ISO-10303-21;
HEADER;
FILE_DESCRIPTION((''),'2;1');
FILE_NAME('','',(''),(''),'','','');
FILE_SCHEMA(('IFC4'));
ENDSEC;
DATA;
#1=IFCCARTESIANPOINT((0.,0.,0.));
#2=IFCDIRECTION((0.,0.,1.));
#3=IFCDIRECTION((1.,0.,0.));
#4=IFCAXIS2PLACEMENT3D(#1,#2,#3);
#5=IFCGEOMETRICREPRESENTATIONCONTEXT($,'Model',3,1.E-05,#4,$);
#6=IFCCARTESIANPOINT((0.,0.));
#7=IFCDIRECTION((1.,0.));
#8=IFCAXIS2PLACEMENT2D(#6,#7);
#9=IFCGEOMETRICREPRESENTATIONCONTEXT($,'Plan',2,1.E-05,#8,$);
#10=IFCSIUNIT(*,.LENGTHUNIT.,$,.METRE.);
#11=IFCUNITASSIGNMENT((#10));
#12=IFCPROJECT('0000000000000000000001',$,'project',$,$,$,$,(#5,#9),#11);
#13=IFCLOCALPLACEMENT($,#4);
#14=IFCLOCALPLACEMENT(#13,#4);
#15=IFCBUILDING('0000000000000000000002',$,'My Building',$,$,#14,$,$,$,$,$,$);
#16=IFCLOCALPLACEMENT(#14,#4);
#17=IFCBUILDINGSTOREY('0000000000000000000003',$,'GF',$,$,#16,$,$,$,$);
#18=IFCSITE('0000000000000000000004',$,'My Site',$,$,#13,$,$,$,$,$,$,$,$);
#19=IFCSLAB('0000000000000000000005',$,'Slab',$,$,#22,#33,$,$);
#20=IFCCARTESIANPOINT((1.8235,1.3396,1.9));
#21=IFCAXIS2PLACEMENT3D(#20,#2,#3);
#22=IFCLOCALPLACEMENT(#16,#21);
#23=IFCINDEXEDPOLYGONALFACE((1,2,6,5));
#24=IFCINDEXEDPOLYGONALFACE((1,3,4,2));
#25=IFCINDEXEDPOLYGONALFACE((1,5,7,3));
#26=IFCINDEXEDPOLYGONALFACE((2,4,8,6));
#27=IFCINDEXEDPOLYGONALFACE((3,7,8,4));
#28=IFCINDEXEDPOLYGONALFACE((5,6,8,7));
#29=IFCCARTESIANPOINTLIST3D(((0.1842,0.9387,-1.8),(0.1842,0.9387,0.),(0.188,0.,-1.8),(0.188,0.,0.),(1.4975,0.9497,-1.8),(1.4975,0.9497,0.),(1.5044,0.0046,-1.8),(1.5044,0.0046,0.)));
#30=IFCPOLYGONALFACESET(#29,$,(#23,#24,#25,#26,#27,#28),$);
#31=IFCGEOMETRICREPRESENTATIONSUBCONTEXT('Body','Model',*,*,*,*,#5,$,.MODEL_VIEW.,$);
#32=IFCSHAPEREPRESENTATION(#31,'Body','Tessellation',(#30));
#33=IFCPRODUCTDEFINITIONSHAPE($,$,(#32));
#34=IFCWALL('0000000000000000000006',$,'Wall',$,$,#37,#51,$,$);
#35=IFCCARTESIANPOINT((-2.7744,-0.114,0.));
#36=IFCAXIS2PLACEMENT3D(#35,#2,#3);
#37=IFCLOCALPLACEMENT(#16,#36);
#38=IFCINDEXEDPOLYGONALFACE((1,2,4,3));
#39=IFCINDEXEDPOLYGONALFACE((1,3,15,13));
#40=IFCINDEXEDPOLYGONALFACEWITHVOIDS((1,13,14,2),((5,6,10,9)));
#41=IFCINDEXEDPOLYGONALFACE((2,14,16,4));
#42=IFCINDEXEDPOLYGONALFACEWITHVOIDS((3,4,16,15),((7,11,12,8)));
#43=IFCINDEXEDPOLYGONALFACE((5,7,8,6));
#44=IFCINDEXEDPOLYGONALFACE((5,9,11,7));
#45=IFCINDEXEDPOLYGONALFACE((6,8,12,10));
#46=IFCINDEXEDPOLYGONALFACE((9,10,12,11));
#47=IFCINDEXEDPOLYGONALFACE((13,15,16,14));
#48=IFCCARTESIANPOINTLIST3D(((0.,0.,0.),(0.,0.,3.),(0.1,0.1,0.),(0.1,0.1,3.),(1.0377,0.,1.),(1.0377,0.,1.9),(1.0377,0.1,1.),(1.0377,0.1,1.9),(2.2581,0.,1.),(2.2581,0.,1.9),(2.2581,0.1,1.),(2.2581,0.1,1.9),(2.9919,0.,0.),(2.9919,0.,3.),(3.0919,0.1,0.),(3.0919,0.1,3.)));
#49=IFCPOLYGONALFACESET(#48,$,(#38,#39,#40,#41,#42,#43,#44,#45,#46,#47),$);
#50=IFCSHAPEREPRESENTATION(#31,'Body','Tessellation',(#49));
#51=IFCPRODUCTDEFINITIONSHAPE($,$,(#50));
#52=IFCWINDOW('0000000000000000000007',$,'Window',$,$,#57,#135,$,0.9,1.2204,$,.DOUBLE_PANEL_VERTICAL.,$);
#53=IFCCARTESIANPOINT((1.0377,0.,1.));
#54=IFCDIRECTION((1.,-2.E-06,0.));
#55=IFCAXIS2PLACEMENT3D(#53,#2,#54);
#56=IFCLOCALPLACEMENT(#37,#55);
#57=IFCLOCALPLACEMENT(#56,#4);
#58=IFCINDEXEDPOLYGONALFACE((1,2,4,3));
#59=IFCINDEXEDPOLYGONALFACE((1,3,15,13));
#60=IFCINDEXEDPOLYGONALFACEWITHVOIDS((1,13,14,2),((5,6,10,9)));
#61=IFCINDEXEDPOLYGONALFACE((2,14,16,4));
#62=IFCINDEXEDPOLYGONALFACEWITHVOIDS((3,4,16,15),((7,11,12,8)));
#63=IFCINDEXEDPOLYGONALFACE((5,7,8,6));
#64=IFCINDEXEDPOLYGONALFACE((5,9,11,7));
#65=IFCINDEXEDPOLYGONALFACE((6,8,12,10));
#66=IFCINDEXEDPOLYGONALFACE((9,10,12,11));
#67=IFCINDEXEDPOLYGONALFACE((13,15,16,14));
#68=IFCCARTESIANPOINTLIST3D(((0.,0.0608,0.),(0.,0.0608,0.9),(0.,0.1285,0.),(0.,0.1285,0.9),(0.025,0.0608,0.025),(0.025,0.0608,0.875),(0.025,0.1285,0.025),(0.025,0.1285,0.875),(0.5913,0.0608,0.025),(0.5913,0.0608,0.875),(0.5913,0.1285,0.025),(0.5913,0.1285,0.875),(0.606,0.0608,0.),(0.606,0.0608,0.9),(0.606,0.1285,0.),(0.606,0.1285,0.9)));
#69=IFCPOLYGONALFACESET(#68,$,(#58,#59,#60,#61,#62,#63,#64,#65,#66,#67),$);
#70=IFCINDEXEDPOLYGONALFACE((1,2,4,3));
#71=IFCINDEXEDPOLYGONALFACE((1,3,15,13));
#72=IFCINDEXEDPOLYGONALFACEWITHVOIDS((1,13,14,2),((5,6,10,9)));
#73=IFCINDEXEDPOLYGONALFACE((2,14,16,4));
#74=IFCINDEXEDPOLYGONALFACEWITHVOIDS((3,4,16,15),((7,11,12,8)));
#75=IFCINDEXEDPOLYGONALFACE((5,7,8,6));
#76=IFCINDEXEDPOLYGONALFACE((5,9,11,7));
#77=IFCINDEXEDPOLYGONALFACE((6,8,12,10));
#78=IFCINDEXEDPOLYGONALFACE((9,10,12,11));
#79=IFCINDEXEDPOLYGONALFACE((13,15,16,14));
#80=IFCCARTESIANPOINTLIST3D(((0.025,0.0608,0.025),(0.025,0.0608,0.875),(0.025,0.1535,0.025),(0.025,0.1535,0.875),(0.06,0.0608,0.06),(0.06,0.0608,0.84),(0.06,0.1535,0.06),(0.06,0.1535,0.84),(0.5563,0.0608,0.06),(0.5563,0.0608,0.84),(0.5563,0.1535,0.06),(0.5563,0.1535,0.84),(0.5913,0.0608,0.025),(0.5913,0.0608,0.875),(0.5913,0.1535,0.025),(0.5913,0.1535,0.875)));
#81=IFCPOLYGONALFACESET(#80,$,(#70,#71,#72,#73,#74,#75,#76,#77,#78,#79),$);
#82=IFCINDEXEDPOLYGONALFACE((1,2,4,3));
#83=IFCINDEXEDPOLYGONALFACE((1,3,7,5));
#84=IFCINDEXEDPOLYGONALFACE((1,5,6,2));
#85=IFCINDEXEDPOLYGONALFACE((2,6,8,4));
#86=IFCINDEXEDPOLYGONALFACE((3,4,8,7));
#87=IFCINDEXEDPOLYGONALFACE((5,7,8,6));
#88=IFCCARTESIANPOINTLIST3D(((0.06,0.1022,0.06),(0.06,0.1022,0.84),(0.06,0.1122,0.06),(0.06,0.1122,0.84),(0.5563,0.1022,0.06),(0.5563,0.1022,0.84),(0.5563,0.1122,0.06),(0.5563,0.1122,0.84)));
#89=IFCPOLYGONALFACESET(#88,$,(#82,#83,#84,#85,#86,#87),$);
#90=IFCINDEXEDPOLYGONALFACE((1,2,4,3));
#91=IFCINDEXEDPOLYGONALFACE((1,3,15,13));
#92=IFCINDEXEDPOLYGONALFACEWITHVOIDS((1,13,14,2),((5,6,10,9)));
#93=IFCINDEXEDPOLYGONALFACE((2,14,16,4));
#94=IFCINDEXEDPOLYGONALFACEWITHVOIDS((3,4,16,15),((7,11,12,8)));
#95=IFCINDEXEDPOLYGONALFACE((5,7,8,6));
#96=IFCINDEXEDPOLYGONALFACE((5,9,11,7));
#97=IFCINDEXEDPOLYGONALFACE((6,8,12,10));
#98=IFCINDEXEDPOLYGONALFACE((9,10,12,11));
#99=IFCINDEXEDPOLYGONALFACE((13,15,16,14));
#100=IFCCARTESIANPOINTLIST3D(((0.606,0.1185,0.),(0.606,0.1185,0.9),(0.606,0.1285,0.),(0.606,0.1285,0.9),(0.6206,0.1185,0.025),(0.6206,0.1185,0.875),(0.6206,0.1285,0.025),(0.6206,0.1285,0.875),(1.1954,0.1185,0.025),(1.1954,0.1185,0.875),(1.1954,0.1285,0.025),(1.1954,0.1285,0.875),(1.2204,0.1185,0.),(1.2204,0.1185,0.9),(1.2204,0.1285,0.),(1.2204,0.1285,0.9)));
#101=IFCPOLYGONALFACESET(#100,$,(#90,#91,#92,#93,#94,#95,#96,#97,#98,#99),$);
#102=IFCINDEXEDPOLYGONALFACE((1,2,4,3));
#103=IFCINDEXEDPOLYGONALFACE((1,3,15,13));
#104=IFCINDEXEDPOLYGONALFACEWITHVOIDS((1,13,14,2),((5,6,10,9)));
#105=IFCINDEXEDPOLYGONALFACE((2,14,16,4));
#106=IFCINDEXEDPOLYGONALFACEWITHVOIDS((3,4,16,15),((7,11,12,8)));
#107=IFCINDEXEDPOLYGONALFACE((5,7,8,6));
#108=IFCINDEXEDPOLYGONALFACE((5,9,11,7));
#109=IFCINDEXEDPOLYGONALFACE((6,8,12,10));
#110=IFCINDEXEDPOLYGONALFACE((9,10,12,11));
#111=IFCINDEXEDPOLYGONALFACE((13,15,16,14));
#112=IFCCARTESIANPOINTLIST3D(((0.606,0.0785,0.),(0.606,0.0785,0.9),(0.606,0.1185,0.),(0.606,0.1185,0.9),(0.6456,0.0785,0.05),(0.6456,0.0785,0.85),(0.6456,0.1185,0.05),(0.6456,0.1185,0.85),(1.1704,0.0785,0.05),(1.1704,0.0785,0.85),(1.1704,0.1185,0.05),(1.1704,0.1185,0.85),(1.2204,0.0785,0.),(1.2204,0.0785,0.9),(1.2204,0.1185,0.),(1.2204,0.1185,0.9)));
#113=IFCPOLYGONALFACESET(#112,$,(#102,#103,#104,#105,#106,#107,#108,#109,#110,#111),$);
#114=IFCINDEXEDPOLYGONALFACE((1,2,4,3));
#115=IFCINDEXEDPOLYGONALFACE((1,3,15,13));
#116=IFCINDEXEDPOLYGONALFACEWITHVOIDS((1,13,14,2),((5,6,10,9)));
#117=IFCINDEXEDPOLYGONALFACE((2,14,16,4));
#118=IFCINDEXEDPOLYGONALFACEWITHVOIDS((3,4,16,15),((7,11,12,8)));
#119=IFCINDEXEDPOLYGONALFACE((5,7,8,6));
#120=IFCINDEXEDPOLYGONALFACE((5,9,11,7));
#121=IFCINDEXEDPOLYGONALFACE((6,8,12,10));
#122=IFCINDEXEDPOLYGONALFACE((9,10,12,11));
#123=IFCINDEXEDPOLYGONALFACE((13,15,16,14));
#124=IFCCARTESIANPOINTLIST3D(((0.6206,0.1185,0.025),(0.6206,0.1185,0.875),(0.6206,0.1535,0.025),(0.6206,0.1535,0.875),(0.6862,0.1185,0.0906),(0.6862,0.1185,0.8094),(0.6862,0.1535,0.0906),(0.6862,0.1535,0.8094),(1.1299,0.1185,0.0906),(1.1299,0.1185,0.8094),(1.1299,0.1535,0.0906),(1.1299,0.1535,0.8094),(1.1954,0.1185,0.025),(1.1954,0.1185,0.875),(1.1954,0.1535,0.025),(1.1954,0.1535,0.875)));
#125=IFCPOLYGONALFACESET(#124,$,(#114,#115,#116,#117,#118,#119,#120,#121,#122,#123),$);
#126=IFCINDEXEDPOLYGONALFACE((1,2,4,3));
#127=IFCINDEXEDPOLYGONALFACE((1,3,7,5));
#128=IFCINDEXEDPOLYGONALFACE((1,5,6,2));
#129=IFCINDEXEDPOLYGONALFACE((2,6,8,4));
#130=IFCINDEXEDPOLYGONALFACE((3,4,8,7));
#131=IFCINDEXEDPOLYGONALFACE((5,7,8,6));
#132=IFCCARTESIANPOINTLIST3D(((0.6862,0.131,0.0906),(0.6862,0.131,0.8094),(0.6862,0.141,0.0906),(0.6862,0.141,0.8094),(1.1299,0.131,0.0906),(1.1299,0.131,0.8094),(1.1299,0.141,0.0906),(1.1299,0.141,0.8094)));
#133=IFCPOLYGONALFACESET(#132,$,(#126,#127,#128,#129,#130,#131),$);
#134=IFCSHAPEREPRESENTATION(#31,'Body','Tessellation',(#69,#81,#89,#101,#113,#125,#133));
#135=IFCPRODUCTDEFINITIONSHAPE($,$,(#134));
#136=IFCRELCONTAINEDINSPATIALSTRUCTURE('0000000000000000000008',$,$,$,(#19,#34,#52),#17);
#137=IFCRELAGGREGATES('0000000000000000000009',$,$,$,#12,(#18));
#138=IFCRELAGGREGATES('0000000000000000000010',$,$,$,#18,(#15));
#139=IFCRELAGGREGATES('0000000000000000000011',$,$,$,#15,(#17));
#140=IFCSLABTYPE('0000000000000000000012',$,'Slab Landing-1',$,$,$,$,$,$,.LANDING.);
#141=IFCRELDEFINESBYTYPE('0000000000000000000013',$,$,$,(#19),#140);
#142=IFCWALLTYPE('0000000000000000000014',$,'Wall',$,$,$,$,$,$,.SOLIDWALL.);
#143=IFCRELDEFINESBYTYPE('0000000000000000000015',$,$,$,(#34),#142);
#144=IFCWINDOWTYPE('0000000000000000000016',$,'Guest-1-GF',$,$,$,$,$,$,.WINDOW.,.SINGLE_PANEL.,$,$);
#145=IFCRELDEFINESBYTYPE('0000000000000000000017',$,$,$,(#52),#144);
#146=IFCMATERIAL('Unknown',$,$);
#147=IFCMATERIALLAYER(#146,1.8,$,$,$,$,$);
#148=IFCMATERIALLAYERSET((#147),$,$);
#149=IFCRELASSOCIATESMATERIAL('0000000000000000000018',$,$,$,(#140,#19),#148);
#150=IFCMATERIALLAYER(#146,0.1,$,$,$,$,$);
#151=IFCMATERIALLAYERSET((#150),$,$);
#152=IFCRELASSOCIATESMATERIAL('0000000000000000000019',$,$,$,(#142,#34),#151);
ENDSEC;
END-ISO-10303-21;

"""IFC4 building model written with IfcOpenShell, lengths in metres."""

from ifc_helpers import new_model, entity, si_unit, frame, origin_with_axes, origin_2d_with_axis, place, context, subcontext, project, spatial, line, indexed_curve, outline, extrude, shape, source, transform, mapped, material, layer, layer_set, layer_usage, type_object, type_shapes, element, fill, save


model = new_model("IFC4")

# Units and contexts
model_context = context("Model", 3, precision=1e-05, world=origin_with_axes())
plan_context = context("Plan", 2, precision=1e-05, world=origin_2d_with_axis())
body_context_1 = subcontext(model_context, "Body", "Model", "MODEL_VIEW")
body_context_2 = subcontext(plan_context, "Body", "Plan", "PLAN_VIEW")
ifc_project = project(units=[si_unit("LENGTHUNIT", "METRE")], contexts=[model_context, plan_context])

# Site, building, storey
site_placement = place(None, origin_with_axes())
site = spatial("IfcSite", under=ifc_project, at=site_placement, Name="My Site")
building_placement = place(site_placement, origin_with_axes())
building = spatial("IfcBuilding", under=site, at=building_placement, Name="My Building")
storey_placement = place(building_placement, origin_with_axes())
storey = spatial("IfcBuildingStorey", under=building, at=storey_placement, Name="GF")

# Slab
ifc_material_1 = material(Name="Unknown")
ifc_layer_1 = layer(ifc_material_1, 1.8)
ifc_layer_set_1 = layer_set([ifc_layer_1])
ifc_layer_usage_1 = layer_usage(ifc_layer_set_1, "AXIS3", "POSITIVE", -1.8)
slab_type_1 = type_object("IfcSlabType", Name="Slab Landing-1", PredefinedType="LANDING", material=ifc_layer_set_1)
slab_1_placement = place(storey_placement, frame((1.8235, 1.3396, 1.9), z_axis=(0.0, 0.0, 1.0), x_axis=(1.0, 0.0, 0.0)))
element("IfcSlab", 1, at=slab_1_placement, inside=storey, type_object=slab_type_1, material=ifc_layer_usage_1, Name="Slab", context=body_context_1, shape_type="SweptSolid", body=[
    extrude(outline(indexed_curve([(0.1842, 0.9387), (1.4975, 0.9497), (1.5044, 0.0046), (0.188, 0.0), (0.1842, 0.9387)])), frame((0.0, 0.0, -1.8), z_axis=(0.0, 0.0, 1.0), x_axis=(1.0, 0.0, 0.0)), (0.0, 0.0, 1.0), 1.8),
])

# Shared definitions
ifc_layer_2 = layer(ifc_material_1, 0.1)
ifc_layer_set_2 = layer_set([ifc_layer_2])
wall_type = type_object("IfcWallType", Name="Wall", PredefinedType="SOLIDWALL", material=ifc_layer_set_2)

# Wall, opening, window
ifc_layer_usage_2 = layer_usage(ifc_layer_set_2, "AXIS2", "POSITIVE", 0.0)
wall_1_placement = place(storey_placement, frame((-2.7744, -0.114, 0.0), z_axis=(0.0, 0.0, 1.0), x_axis=(1.0, 0.0, 0.0)))
wall_1 = element("IfcWall", 2, at=wall_1_placement, inside=storey, type_object=wall_type, material=ifc_layer_usage_2, Name="Wall", context=body_context_1, shape_type="SweptSolid", body=[
    extrude(outline(indexed_curve([(0.0, 0.0), (0.1, 0.1), (3.0919, 0.1), (2.9919, 0.0)], segments=[line(1, 2, 3, 4, 1)])), origin_with_axes(), (0.0, 0.0, 1.0), 3.0),
])
shared_shape_1 = source(origin_with_axes(), body_context_1, "Body", "SweptSolid", [
    extrude(outline(indexed_curve([(0.0, 0.0), (1.2204, 0.0), (1.2204, 0.9), (0.0, 0.9)], segments=[line(1, 2, 3, 4, 1)])), frame((0.0, -0.6, 0.0), z_axis=(0.0, -1.0, 0.0), x_axis=(1.0, 0.0, 0.0)), (0.0, 0.0, -1.0), 1.2),
])
opening_1_placement = place(wall_1_placement, frame((1.0377, 0.0, 1.0), z_axis=(0.0, 0.0, 1.0), x_axis=(1.0, -0.000002, 0.0)))
opening_1 = element("IfcOpeningElement", 3, at=opening_1_placement, cuts=wall_1, PredefinedType="OPENING", context=body_context_1, shape_type="MappedRepresentation", body=[
    mapped(shared_shape_1, transform((0.0, 0.0, 0.0), x_axis=(1.0, 0.0, 0.0), y_axis=(0.0, 1.0, 0.0), z_axis=(0.0, 0.0, 1.0), scale=1.0)),
])
window_type_1 = type_object("IfcWindowType", Name="Guest-1-GF", PartitioningType="SINGLE_PANEL", PredefinedType="WINDOW")
shared_shape_2 = source(origin_with_axes(), body_context_1, "Body", "SweptSolid", [
    extrude(outline(indexed_curve([(0.0, 0.0), (0.606, 0.0), (0.606, 0.9), (0.0, 0.9)], segments=[line(1, 2, 3, 4, 1)]), holes=[indexed_curve([(0.025, 0.025), (0.5913, 0.025), (0.5913, 0.875), (0.025, 0.875)], segments=[line(1, 2, 3, 4, 1)])]), frame((0.0, 0.0608, 0.0), z_axis=(0.0, -1.0, 0.0), x_axis=(1.0, 0.0, 0.0)), (0.0, 0.0, -1.0), 0.0677),
    extrude(outline(indexed_curve([(0.0, 0.0), (0.606, 0.0), (0.606, 0.9), (0.0, 0.9)], segments=[line(1, 2, 3, 4, 1)]), holes=[indexed_curve([(0.05, 0.05), (0.5663, 0.05), (0.5663, 0.85), (0.05, 0.85)], segments=[line(1, 2, 3, 4, 1)])]), frame((0.0, 0.0785, 0.0), z_axis=(0.0, -1.0, 0.0), x_axis=(1.0, 0.0, 0.0)), (0.0, 0.0, -1.0), -0.0177),
    extrude(outline(indexed_curve([(0.0, 0.0), (0.5663, 0.0), (0.5663, 0.85), (0.0, 0.85)], segments=[line(1, 2, 3, 4, 1)]), holes=[indexed_curve([(0.035, 0.035), (0.5313, 0.035), (0.5313, 0.815), (0.035, 0.815)], segments=[line(1, 2, 3, 4, 1)])]), frame((0.025, 0.0608, 0.025), z_axis=(0.0, -1.0, 0.0), x_axis=(1.0, 0.0, 0.0)), (0.0, 0.0, -1.0), 0.0927),
    extrude(outline(indexed_curve([(0.035, 0.035), (0.5313, 0.035), (0.5313, 0.815), (0.035, 0.815)], segments=[line(1, 2, 3, 4, 1)])), frame((0.025, 0.1022, 0.025), z_axis=(0.0, -1.0, 0.0), x_axis=(1.0, 0.0, 0.0)), (0.0, 0.0, -1.0), 0.01),
    extrude(outline(indexed_curve([(0.0, 0.0), (0.6144, 0.0), (0.6144, 0.9), (0.0, 0.9)], segments=[line(1, 2, 3, 4, 1)]), holes=[indexed_curve([(0.0147, 0.025), (0.5894, 0.025), (0.5894, 0.875), (0.0147, 0.875)], segments=[line(1, 2, 3, 4, 1)])]), frame((0.606, 0.1185, 0.0), z_axis=(0.0, -1.0, 0.0), x_axis=(1.0, 0.0, 0.0)), (0.0, 0.0, -1.0), 0.01),
    extrude(outline(indexed_curve([(0.0, 0.0), (0.6144, 0.0), (0.6144, 0.9), (0.0, 0.9)], segments=[line(1, 2, 3, 4, 1)]), holes=[indexed_curve([(0.0397, 0.05), (0.5644, 0.05), (0.5644, 0.85), (0.0397, 0.85)], segments=[line(1, 2, 3, 4, 1)])]), frame((0.606, 0.0785, 0.0), z_axis=(0.0, -1.0, 0.0), x_axis=(1.0, 0.0, 0.0)), (0.0, 0.0, -1.0), 0.04),
    extrude(outline(indexed_curve([(0.0, 0.0), (0.5748, 0.0), (0.5748, 0.85), (0.0, 0.85)], segments=[line(1, 2, 3, 4, 1)]), holes=[indexed_curve([(0.0656, 0.0656), (0.5092, 0.0656), (0.5092, 0.7844), (0.0656, 0.7844)], segments=[line(1, 2, 3, 4, 1)])]), frame((0.6206, 0.1185, 0.025), z_axis=(0.0, -1.0, 0.0), x_axis=(1.0, 0.0, 0.0)), (0.0, 0.0, -1.0), 0.035),
    extrude(outline(indexed_curve([(0.0656, 0.0656), (0.5092, 0.0656), (0.5092, 0.7844), (0.0656, 0.7844)], segments=[line(1, 2, 3, 4, 1)])), frame((0.6206, 0.131, 0.025), z_axis=(0.0, -1.0, 0.0), x_axis=(1.0, 0.0, 0.0)), (0.0, 0.0, -1.0), 0.01),
])
shared_shape_3 = source(origin_with_axes(), body_context_2, "Body", "Curve2D", [
    entity("IfcIndexedPolyCurve", entity("IfcCartesianPointList2D", [[0.05, 0.0785], [0.5663, 0.0785]])),
    entity("IfcIndexedPolyCurve", entity("IfcCartesianPointList2D", [[0.0, 0.1285], [0.025, 0.1285], [0.025, 0.0608], [0.05, 0.0608], [0.05, 0.0785], [0.0, 0.0785]]), [entity("IfcLineIndex", [1, 2, 3, 4, 5, 6, 1])]),
    entity("IfcIndexedPolyCurve", entity("IfcCartesianPointList2D", [[0.606, 0.1285], [0.5913, 0.1285], [0.5913, 0.0608], [0.5663, 0.0608], [0.5663, 0.0785], [0.606, 0.0785]])),
    entity("IfcIndexedPolyCurve", entity("IfcCartesianPointList2D", [[0.025, 0.0608], [0.06, 0.0608], [0.06, 0.1535], [0.025, 0.1535]]), [entity("IfcLineIndex", [1, 2, 3, 4, 1])]),
    entity("IfcIndexedPolyCurve", entity("IfcCartesianPointList2D", [[0.5913, 0.0608], [0.5563, 0.0608], [0.5563, 0.1535], [0.5913, 0.1535]]), [entity("IfcLineIndex", [1, 2, 3, 4, 1])]),
    entity("IfcIndexedPolyCurve", entity("IfcCartesianPointList2D", [[0.06, 0.0608], [0.5563, 0.0608]])),
    entity("IfcIndexedPolyCurve", entity("IfcCartesianPointList2D", [[0.06, 0.1535], [0.5563, 0.1535]])),
    entity("IfcIndexedPolyCurve", entity("IfcCartesianPointList2D", [[0.06, 0.1072], [0.5563, 0.1072]])),
    entity("IfcIndexedPolyCurve", entity("IfcCartesianPointList2D", [[0.6456, 0.0785], [1.1704, 0.0785]])),
    entity("IfcIndexedPolyCurve", entity("IfcCartesianPointList2D", [[0.606, 0.1285], [0.6206, 0.1285], [0.6206, 0.1185], [0.6456, 0.1185], [0.6456, 0.0785], [0.606, 0.0785]])),
    entity("IfcIndexedPolyCurve", entity("IfcCartesianPointList2D", [[1.2204, 0.1285], [1.1954, 0.1285], [1.1954, 0.1185], [1.1704, 0.1185], [1.1704, 0.0785], [1.2204, 0.0785]]), [entity("IfcLineIndex", [1, 2, 3, 4, 5, 6, 1])]),
    entity("IfcIndexedPolyCurve", entity("IfcCartesianPointList2D", [[0.6206, 0.1185], [0.6862, 0.1185], [0.6862, 0.1535], [0.6206, 0.1535]]), [entity("IfcLineIndex", [1, 2, 3, 4, 1])]),
    entity("IfcIndexedPolyCurve", entity("IfcCartesianPointList2D", [[1.1954, 0.1185], [1.1299, 0.1185], [1.1299, 0.1535], [1.1954, 0.1535]]), [entity("IfcLineIndex", [1, 2, 3, 4, 1])]),
    entity("IfcIndexedPolyCurve", entity("IfcCartesianPointList2D", [[0.6862, 0.1185], [1.1299, 0.1185]])),
    entity("IfcIndexedPolyCurve", entity("IfcCartesianPointList2D", [[0.6862, 0.1535], [1.1299, 0.1535]])),
    entity("IfcIndexedPolyCurve", entity("IfcCartesianPointList2D", [[0.6862, 0.136], [1.1299, 0.136]])),
])
type_shapes(window_type_1, [shared_shape_2, shared_shape_3])
window_1_placement = place(opening_1_placement, frame((0.0, 0.0, 0.0), z_axis=(0.0, 0.0, 1.0), x_axis=(1.0, 0.0, 0.0)))
window_1 = element("IfcWindow", 4, at=window_1_placement, inside=storey, type_object=window_type_1, Name="Window", OverallHeight=0.9, OverallWidth=1.2204, PartitioningType="DOUBLE_PANEL_VERTICAL", shapes=[
    shape(body_context_1, "Body", "MappedRepresentation", [mapped(shared_shape_2, transform((0.0, 0.0, 0.0), x_axis=(1.0, 0.0, 0.0), y_axis=(0.0, 1.0, 0.0), z_axis=(0.0, 0.0, 1.0), scale=1.0))]),
    shape(body_context_2, "Body", "MappedRepresentation", [mapped(shared_shape_3, transform((0.0, 0.0, 0.0), x_axis=(1.0, 0.0, 0.0), y_axis=(0.0, 1.0, 0.0), z_axis=(0.0, 0.0, 1.0), scale=1.0))]),
])
fill(opening_1, window_1)

save(model, "model.ifc")
